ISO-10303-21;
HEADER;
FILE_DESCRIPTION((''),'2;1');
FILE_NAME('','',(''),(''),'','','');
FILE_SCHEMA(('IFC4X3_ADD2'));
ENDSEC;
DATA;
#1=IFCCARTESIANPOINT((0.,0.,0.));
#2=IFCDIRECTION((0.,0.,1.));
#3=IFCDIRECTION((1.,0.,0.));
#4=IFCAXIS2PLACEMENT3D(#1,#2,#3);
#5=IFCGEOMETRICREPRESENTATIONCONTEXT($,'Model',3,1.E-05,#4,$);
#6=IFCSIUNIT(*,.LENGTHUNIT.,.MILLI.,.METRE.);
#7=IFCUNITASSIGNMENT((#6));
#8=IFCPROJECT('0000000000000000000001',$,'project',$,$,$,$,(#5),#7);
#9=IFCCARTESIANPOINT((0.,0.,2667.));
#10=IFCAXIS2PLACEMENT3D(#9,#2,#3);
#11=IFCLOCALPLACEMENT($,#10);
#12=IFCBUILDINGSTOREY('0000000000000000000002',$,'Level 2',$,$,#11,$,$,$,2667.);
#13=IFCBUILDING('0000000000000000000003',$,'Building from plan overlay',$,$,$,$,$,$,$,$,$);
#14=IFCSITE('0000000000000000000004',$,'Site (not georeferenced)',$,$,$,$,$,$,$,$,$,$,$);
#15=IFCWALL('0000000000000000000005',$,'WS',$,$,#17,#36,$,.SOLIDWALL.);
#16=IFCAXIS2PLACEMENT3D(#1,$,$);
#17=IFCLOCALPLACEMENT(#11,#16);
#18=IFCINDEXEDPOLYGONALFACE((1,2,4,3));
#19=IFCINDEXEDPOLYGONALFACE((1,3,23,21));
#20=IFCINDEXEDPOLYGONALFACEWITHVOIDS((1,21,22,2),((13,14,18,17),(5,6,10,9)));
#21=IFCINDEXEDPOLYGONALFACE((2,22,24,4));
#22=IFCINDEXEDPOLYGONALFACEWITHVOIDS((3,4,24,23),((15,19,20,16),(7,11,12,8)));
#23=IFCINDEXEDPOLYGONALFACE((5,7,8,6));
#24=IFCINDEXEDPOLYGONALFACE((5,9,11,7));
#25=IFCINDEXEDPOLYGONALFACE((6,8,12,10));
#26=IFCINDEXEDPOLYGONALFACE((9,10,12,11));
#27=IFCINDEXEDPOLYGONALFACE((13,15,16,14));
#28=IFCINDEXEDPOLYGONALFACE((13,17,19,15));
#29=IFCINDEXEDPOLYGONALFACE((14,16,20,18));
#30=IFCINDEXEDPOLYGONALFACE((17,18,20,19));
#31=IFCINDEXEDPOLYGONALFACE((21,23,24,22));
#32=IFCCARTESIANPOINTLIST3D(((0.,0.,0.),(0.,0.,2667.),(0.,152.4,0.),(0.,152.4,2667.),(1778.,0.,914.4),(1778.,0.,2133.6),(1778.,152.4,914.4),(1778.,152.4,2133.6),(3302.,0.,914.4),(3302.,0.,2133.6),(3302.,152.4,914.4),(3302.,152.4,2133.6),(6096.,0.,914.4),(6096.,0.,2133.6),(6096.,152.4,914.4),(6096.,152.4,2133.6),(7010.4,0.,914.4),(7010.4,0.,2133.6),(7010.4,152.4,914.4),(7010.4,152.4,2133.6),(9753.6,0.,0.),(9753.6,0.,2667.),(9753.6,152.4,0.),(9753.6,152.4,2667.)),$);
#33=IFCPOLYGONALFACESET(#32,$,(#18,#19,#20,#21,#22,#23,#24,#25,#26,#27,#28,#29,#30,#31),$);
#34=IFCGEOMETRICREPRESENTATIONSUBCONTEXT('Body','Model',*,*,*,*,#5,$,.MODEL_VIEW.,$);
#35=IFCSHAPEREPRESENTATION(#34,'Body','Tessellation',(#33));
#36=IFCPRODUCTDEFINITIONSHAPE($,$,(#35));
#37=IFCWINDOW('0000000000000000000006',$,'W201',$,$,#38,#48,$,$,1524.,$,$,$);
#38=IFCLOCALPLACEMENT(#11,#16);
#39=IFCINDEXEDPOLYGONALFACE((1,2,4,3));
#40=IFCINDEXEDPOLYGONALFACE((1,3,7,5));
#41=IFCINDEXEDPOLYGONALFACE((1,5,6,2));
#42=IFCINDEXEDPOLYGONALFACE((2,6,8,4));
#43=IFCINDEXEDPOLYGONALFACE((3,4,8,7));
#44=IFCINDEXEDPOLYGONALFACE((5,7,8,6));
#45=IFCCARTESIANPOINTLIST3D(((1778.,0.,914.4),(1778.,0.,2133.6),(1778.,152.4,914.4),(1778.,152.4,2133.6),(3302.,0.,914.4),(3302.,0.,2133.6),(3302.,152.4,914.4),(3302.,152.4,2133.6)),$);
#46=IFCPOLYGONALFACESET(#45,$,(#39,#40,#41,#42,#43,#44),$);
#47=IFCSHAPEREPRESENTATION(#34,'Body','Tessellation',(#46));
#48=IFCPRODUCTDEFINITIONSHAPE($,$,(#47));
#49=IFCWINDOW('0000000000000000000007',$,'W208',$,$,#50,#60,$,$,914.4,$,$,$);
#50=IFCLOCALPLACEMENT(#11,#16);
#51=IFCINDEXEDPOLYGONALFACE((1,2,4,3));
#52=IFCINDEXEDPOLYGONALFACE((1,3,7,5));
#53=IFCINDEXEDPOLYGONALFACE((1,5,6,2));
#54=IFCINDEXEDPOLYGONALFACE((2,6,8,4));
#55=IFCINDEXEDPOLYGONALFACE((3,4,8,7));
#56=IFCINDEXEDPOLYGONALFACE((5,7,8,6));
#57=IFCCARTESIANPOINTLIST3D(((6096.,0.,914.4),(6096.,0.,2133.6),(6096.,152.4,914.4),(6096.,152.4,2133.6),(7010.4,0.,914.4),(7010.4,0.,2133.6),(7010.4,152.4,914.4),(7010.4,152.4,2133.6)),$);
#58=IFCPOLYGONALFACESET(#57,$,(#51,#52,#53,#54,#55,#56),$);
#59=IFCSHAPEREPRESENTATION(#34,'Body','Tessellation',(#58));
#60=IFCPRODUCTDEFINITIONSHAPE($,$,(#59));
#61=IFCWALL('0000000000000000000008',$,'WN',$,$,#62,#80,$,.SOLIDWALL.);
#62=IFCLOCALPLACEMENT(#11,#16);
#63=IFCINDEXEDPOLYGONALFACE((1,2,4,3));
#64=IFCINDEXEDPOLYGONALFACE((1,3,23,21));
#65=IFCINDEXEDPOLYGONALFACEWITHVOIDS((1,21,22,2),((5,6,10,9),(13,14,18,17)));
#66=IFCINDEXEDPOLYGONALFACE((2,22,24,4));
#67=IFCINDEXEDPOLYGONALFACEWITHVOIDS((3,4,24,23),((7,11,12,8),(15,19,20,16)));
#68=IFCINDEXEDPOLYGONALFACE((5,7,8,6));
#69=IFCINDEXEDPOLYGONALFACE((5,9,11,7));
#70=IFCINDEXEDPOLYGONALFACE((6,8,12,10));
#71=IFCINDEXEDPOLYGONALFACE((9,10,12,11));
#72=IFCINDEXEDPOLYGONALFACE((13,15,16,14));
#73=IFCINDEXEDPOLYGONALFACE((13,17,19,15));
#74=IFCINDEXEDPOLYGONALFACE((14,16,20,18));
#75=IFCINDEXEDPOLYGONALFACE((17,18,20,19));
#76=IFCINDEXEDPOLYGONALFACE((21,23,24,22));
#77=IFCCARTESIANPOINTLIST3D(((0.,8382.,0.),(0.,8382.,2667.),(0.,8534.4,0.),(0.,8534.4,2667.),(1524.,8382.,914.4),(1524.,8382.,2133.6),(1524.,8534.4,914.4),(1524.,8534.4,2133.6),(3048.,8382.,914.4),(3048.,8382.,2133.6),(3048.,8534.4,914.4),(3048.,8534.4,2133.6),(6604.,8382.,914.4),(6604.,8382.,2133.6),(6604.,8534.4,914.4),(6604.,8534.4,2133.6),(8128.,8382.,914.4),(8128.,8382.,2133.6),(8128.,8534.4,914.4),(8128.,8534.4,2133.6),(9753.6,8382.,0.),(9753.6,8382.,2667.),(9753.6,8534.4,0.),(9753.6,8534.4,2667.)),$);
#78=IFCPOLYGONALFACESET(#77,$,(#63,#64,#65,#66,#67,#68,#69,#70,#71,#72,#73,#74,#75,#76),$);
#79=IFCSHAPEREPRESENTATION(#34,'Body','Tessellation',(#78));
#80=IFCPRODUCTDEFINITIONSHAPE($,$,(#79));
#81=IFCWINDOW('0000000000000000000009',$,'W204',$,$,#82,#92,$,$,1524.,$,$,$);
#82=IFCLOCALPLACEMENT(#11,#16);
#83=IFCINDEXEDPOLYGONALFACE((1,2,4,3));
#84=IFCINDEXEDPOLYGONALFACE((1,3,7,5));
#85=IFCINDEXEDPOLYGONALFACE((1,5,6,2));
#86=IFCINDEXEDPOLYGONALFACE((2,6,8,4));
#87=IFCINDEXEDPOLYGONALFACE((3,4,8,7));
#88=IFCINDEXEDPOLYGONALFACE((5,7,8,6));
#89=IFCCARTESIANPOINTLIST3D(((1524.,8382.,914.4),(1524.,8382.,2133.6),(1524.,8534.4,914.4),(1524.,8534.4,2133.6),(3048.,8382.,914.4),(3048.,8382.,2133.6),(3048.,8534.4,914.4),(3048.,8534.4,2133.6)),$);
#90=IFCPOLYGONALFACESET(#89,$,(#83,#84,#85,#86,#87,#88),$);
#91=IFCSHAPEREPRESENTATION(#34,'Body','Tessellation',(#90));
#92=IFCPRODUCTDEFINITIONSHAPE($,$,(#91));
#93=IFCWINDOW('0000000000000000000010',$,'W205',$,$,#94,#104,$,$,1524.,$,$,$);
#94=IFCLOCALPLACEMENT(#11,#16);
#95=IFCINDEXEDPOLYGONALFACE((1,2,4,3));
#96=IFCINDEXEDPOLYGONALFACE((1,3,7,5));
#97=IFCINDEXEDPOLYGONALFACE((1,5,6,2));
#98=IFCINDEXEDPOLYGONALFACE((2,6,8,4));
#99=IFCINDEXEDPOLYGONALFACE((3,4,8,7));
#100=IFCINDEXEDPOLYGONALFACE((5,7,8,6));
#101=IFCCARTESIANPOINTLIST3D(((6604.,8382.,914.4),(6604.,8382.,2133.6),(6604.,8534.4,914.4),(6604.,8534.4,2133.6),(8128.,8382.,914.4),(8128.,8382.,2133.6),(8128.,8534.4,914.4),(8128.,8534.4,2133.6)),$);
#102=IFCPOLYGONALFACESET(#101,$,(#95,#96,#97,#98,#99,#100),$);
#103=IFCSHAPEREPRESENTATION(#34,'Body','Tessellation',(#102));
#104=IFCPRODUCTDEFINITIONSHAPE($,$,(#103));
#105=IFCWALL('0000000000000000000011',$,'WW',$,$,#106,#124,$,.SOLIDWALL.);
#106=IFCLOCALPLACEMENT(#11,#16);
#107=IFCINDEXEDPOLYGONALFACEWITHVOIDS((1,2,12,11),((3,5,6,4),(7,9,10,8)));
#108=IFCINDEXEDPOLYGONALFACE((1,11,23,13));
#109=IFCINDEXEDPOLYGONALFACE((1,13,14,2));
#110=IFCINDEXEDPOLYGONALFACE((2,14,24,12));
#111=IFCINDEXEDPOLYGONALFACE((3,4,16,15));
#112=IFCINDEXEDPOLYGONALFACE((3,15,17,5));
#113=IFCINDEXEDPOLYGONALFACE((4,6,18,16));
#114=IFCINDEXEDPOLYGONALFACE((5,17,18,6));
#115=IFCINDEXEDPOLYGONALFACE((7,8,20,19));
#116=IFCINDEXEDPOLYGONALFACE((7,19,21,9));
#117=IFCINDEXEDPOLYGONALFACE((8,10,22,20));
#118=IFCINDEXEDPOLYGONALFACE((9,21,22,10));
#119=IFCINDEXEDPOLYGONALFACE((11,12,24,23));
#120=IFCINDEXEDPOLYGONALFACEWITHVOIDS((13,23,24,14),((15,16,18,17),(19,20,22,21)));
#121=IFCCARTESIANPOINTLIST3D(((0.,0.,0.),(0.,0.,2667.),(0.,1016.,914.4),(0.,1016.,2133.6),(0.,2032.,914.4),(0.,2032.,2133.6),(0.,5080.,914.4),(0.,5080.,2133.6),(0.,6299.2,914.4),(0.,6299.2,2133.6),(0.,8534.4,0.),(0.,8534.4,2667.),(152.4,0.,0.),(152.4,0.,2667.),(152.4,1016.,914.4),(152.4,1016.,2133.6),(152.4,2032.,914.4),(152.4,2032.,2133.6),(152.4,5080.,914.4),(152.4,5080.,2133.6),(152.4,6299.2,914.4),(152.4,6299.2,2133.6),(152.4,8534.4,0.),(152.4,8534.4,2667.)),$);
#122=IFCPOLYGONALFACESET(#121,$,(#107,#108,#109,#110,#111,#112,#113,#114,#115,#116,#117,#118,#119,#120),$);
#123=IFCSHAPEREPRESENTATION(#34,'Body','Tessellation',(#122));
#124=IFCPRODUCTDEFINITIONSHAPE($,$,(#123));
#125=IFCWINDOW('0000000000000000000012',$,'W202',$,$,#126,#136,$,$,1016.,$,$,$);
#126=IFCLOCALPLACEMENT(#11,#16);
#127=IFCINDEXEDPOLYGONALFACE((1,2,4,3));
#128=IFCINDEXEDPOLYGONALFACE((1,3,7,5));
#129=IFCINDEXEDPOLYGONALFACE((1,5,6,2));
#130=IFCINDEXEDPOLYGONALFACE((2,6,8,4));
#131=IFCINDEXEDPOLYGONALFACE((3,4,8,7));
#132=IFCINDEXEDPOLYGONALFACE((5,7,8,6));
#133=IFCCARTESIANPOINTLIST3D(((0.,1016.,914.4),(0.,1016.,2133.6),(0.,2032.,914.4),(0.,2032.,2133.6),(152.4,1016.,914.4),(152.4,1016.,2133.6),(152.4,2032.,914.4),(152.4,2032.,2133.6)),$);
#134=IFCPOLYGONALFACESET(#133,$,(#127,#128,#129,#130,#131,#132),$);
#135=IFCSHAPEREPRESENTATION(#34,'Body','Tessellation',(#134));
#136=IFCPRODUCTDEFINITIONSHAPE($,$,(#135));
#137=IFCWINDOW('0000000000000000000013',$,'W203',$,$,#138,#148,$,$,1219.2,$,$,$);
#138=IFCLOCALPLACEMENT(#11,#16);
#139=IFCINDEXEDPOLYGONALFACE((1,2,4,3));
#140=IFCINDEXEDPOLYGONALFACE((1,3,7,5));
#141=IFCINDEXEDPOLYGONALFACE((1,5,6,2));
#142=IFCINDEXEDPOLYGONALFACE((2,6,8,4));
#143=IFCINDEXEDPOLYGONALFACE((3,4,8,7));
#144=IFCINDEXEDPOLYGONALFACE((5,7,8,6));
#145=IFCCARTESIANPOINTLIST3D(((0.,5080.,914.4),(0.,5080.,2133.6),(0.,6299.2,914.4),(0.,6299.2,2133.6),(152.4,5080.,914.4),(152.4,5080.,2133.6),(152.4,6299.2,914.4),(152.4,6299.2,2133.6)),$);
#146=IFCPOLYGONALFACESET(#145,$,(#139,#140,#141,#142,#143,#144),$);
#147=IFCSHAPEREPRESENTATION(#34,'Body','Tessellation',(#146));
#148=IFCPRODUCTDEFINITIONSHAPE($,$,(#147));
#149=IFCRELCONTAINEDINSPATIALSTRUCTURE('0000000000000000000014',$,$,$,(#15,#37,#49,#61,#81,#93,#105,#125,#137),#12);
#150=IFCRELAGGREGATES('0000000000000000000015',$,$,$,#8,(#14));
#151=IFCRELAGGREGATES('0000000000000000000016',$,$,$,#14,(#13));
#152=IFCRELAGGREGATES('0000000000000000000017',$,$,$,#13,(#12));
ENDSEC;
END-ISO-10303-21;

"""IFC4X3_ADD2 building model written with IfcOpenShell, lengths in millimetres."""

from ifc_helpers import new_model, si_unit, frame, origin, origin_with_axes, place, context, subcontext, project, spatial, polyline, outline, extrude, element, fill, save


model = new_model("IFC4X3_ADD2")

# Units and contexts
model_context = context("Model", 3, precision=1e-05, world=origin_with_axes())
body_context = subcontext(model_context, "Body", "Model", "MODEL_VIEW")
ifc_project = project(units=[si_unit("LENGTHUNIT", "METRE", prefix="MILLI")], contexts=[model_context])

# Site, building, storey
site = spatial("IfcSite", under=ifc_project, Name="Site (not georeferenced)")
building = spatial("IfcBuilding", under=site, Name="Building from plan overlay")
storey_placement = place(None, frame((0.0, 0.0, 2667.0), z_axis=(0.0, 0.0, 1.0), x_axis=(1.0, 0.0, 0.0)))
storey = spatial("IfcBuildingStorey", under=building, at=storey_placement, Name="Level 2", Elevation=2667.0)

# Walls, openings, windows
wall_1_placement = place(storey_placement, origin_with_axes())
wall_1 = element("IfcWall", 1, at=wall_1_placement, inside=storey, Name="WS", PredefinedType="SOLIDWALL", context=body_context, shape_type="SweptSolid", body=[
    extrude(outline(polyline([(0.0, 0.0), (9753.6, 0.0), (9753.6, 152.4), (0.0, 152.4), (0.0, 0.0)])), origin(), (0.0, 0.0, 1.0), 2667.0),
])
opening_1_placement = place(wall_1_placement, origin_with_axes())
opening_1 = element("IfcOpeningElement", 2, at=opening_1_placement, cuts=wall_1, context=body_context, shape_type="SweptSolid", body=[
    extrude(outline(polyline([(1778.0, 0.0), (3302.0, 0.0), (3302.0, 152.4), (1778.0, 152.4), (1778.0, 0.0)])), frame((0.0, 0.0, 914.4)), (0.0, 0.0, 1.0), 1219.2),
])
opening_2_placement = place(wall_1_placement, origin_with_axes())
opening_2 = element("IfcOpeningElement", 3, at=opening_2_placement, cuts=wall_1, context=body_context, shape_type="SweptSolid", body=[
    extrude(outline(polyline([(6096.0, 0.0), (7010.4, 0.0), (7010.4, 152.4), (6096.0, 152.4), (6096.0, 0.0)])), frame((0.0, 0.0, 914.4)), (0.0, 0.0, 1.0), 1219.2),
])
window_1_placement = place(storey_placement, origin_with_axes())
window_1 = element("IfcWindow", 4, at=window_1_placement, inside=storey, Name="W201", OverallWidth=1524.0, context=body_context, shape_type="SweptSolid", body=[
    extrude(outline(polyline([(1778.0, 0.0), (3302.0, 0.0), (3302.0, 152.4), (1778.0, 152.4), (1778.0, 0.0)])), frame((0.0, 0.0, 914.4)), (0.0, 0.0, 1.0), 1219.2),
])
fill(opening_1, window_1)
window_2_placement = place(storey_placement, origin_with_axes())
window_2 = element("IfcWindow", 5, at=window_2_placement, inside=storey, Name="W208", OverallWidth=914.4, context=body_context, shape_type="SweptSolid", body=[
    extrude(outline(polyline([(6096.0, 0.0), (7010.4, 0.0), (7010.4, 152.4), (6096.0, 152.4), (6096.0, 0.0)])), frame((0.0, 0.0, 914.4)), (0.0, 0.0, 1.0), 1219.2),
])
fill(opening_2, window_2)
wall_2_placement = place(storey_placement, origin_with_axes())
wall_2 = element("IfcWall", 6, at=wall_2_placement, inside=storey, Name="WN", PredefinedType="SOLIDWALL", context=body_context, shape_type="SweptSolid", body=[
    extrude(outline(polyline([(0.0, 8382.0), (9753.6, 8382.0), (9753.6, 8534.4), (0.0, 8534.4), (0.0, 8382.0)])), origin(), (0.0, 0.0, 1.0), 2667.0),
])
opening_3_placement = place(wall_2_placement, origin_with_axes())
opening_3 = element("IfcOpeningElement", 7, at=opening_3_placement, cuts=wall_2, context=body_context, shape_type="SweptSolid", body=[
    extrude(outline(polyline([(1524.0, 8382.0), (3048.0, 8382.0), (3048.0, 8534.4), (1524.0, 8534.4), (1524.0, 8382.0)])), frame((0.0, 0.0, 914.4)), (0.0, 0.0, 1.0), 1219.2),
])
opening_4_placement = place(wall_2_placement, origin_with_axes())
opening_4 = element("IfcOpeningElement", 8, at=opening_4_placement, cuts=wall_2, context=body_context, shape_type="SweptSolid", body=[
    extrude(outline(polyline([(6604.0, 8382.0), (8128.0, 8382.0), (8128.0, 8534.4), (6604.0, 8534.4), (6604.0, 8382.0)])), frame((0.0, 0.0, 914.4)), (0.0, 0.0, 1.0), 1219.2),
])
window_3_placement = place(storey_placement, origin_with_axes())
window_3 = element("IfcWindow", 9, at=window_3_placement, inside=storey, Name="W204", OverallWidth=1524.0, context=body_context, shape_type="SweptSolid", body=[
    extrude(outline(polyline([(1524.0, 8382.0), (3048.0, 8382.0), (3048.0, 8534.4), (1524.0, 8534.4), (1524.0, 8382.0)])), frame((0.0, 0.0, 914.4)), (0.0, 0.0, 1.0), 1219.2),
])
fill(opening_3, window_3)
window_4_placement = place(storey_placement, origin_with_axes())
window_4 = element("IfcWindow", 10, at=window_4_placement, inside=storey, Name="W205", OverallWidth=1524.0, context=body_context, shape_type="SweptSolid", body=[
    extrude(outline(polyline([(6604.0, 8382.0), (8128.0, 8382.0), (8128.0, 8534.4), (6604.0, 8534.4), (6604.0, 8382.0)])), frame((0.0, 0.0, 914.4)), (0.0, 0.0, 1.0), 1219.2),
])
fill(opening_4, window_4)
wall_3_placement = place(storey_placement, origin_with_axes())
wall_3 = element("IfcWall", 11, at=wall_3_placement, inside=storey, Name="WW", PredefinedType="SOLIDWALL", context=body_context, shape_type="SweptSolid", body=[
    extrude(outline(polyline([(0.0, 0.0), (152.4, 0.0), (152.4, 8534.4), (0.0, 8534.4), (0.0, 0.0)])), origin(), (0.0, 0.0, 1.0), 2667.0),
])
opening_5_placement = place(wall_3_placement, origin_with_axes())
opening_5 = element("IfcOpeningElement", 12, at=opening_5_placement, cuts=wall_3, context=body_context, shape_type="SweptSolid", body=[
    extrude(outline(polyline([(0.0, 1016.0), (152.4, 1016.0), (152.4, 2032.0), (0.0, 2032.0), (0.0, 1016.0)])), frame((0.0, 0.0, 914.4)), (0.0, 0.0, 1.0), 1219.2),
])
opening_6_placement = place(wall_3_placement, origin_with_axes())
opening_6 = element("IfcOpeningElement", 13, at=opening_6_placement, cuts=wall_3, context=body_context, shape_type="SweptSolid", body=[
    extrude(outline(polyline([(0.0, 5080.0), (152.4, 5080.0), (152.4, 6299.2), (0.0, 6299.2), (0.0, 5080.0)])), frame((0.0, 0.0, 914.4)), (0.0, 0.0, 1.0), 1219.2),
])
window_5_placement = place(storey_placement, origin_with_axes())
window_5 = element("IfcWindow", 14, at=window_5_placement, inside=storey, Name="W202", OverallWidth=1016.0, context=body_context, shape_type="SweptSolid", body=[
    extrude(outline(polyline([(0.0, 1016.0), (152.4, 1016.0), (152.4, 2032.0), (0.0, 2032.0), (0.0, 1016.0)])), frame((0.0, 0.0, 914.4)), (0.0, 0.0, 1.0), 1219.2),
])
fill(opening_5, window_5)
window_6_placement = place(storey_placement, origin_with_axes())
window_6 = element("IfcWindow", 15, at=window_6_placement, inside=storey, Name="W203", OverallWidth=1219.2, context=body_context, shape_type="SweptSolid", body=[
    extrude(outline(polyline([(0.0, 5080.0), (152.4, 5080.0), (152.4, 6299.2), (0.0, 6299.2), (0.0, 5080.0)])), frame((0.0, 0.0, 914.4)), (0.0, 0.0, 1.0), 1219.2),
])
fill(opening_6, window_6)

save(model, "model.ifc")
